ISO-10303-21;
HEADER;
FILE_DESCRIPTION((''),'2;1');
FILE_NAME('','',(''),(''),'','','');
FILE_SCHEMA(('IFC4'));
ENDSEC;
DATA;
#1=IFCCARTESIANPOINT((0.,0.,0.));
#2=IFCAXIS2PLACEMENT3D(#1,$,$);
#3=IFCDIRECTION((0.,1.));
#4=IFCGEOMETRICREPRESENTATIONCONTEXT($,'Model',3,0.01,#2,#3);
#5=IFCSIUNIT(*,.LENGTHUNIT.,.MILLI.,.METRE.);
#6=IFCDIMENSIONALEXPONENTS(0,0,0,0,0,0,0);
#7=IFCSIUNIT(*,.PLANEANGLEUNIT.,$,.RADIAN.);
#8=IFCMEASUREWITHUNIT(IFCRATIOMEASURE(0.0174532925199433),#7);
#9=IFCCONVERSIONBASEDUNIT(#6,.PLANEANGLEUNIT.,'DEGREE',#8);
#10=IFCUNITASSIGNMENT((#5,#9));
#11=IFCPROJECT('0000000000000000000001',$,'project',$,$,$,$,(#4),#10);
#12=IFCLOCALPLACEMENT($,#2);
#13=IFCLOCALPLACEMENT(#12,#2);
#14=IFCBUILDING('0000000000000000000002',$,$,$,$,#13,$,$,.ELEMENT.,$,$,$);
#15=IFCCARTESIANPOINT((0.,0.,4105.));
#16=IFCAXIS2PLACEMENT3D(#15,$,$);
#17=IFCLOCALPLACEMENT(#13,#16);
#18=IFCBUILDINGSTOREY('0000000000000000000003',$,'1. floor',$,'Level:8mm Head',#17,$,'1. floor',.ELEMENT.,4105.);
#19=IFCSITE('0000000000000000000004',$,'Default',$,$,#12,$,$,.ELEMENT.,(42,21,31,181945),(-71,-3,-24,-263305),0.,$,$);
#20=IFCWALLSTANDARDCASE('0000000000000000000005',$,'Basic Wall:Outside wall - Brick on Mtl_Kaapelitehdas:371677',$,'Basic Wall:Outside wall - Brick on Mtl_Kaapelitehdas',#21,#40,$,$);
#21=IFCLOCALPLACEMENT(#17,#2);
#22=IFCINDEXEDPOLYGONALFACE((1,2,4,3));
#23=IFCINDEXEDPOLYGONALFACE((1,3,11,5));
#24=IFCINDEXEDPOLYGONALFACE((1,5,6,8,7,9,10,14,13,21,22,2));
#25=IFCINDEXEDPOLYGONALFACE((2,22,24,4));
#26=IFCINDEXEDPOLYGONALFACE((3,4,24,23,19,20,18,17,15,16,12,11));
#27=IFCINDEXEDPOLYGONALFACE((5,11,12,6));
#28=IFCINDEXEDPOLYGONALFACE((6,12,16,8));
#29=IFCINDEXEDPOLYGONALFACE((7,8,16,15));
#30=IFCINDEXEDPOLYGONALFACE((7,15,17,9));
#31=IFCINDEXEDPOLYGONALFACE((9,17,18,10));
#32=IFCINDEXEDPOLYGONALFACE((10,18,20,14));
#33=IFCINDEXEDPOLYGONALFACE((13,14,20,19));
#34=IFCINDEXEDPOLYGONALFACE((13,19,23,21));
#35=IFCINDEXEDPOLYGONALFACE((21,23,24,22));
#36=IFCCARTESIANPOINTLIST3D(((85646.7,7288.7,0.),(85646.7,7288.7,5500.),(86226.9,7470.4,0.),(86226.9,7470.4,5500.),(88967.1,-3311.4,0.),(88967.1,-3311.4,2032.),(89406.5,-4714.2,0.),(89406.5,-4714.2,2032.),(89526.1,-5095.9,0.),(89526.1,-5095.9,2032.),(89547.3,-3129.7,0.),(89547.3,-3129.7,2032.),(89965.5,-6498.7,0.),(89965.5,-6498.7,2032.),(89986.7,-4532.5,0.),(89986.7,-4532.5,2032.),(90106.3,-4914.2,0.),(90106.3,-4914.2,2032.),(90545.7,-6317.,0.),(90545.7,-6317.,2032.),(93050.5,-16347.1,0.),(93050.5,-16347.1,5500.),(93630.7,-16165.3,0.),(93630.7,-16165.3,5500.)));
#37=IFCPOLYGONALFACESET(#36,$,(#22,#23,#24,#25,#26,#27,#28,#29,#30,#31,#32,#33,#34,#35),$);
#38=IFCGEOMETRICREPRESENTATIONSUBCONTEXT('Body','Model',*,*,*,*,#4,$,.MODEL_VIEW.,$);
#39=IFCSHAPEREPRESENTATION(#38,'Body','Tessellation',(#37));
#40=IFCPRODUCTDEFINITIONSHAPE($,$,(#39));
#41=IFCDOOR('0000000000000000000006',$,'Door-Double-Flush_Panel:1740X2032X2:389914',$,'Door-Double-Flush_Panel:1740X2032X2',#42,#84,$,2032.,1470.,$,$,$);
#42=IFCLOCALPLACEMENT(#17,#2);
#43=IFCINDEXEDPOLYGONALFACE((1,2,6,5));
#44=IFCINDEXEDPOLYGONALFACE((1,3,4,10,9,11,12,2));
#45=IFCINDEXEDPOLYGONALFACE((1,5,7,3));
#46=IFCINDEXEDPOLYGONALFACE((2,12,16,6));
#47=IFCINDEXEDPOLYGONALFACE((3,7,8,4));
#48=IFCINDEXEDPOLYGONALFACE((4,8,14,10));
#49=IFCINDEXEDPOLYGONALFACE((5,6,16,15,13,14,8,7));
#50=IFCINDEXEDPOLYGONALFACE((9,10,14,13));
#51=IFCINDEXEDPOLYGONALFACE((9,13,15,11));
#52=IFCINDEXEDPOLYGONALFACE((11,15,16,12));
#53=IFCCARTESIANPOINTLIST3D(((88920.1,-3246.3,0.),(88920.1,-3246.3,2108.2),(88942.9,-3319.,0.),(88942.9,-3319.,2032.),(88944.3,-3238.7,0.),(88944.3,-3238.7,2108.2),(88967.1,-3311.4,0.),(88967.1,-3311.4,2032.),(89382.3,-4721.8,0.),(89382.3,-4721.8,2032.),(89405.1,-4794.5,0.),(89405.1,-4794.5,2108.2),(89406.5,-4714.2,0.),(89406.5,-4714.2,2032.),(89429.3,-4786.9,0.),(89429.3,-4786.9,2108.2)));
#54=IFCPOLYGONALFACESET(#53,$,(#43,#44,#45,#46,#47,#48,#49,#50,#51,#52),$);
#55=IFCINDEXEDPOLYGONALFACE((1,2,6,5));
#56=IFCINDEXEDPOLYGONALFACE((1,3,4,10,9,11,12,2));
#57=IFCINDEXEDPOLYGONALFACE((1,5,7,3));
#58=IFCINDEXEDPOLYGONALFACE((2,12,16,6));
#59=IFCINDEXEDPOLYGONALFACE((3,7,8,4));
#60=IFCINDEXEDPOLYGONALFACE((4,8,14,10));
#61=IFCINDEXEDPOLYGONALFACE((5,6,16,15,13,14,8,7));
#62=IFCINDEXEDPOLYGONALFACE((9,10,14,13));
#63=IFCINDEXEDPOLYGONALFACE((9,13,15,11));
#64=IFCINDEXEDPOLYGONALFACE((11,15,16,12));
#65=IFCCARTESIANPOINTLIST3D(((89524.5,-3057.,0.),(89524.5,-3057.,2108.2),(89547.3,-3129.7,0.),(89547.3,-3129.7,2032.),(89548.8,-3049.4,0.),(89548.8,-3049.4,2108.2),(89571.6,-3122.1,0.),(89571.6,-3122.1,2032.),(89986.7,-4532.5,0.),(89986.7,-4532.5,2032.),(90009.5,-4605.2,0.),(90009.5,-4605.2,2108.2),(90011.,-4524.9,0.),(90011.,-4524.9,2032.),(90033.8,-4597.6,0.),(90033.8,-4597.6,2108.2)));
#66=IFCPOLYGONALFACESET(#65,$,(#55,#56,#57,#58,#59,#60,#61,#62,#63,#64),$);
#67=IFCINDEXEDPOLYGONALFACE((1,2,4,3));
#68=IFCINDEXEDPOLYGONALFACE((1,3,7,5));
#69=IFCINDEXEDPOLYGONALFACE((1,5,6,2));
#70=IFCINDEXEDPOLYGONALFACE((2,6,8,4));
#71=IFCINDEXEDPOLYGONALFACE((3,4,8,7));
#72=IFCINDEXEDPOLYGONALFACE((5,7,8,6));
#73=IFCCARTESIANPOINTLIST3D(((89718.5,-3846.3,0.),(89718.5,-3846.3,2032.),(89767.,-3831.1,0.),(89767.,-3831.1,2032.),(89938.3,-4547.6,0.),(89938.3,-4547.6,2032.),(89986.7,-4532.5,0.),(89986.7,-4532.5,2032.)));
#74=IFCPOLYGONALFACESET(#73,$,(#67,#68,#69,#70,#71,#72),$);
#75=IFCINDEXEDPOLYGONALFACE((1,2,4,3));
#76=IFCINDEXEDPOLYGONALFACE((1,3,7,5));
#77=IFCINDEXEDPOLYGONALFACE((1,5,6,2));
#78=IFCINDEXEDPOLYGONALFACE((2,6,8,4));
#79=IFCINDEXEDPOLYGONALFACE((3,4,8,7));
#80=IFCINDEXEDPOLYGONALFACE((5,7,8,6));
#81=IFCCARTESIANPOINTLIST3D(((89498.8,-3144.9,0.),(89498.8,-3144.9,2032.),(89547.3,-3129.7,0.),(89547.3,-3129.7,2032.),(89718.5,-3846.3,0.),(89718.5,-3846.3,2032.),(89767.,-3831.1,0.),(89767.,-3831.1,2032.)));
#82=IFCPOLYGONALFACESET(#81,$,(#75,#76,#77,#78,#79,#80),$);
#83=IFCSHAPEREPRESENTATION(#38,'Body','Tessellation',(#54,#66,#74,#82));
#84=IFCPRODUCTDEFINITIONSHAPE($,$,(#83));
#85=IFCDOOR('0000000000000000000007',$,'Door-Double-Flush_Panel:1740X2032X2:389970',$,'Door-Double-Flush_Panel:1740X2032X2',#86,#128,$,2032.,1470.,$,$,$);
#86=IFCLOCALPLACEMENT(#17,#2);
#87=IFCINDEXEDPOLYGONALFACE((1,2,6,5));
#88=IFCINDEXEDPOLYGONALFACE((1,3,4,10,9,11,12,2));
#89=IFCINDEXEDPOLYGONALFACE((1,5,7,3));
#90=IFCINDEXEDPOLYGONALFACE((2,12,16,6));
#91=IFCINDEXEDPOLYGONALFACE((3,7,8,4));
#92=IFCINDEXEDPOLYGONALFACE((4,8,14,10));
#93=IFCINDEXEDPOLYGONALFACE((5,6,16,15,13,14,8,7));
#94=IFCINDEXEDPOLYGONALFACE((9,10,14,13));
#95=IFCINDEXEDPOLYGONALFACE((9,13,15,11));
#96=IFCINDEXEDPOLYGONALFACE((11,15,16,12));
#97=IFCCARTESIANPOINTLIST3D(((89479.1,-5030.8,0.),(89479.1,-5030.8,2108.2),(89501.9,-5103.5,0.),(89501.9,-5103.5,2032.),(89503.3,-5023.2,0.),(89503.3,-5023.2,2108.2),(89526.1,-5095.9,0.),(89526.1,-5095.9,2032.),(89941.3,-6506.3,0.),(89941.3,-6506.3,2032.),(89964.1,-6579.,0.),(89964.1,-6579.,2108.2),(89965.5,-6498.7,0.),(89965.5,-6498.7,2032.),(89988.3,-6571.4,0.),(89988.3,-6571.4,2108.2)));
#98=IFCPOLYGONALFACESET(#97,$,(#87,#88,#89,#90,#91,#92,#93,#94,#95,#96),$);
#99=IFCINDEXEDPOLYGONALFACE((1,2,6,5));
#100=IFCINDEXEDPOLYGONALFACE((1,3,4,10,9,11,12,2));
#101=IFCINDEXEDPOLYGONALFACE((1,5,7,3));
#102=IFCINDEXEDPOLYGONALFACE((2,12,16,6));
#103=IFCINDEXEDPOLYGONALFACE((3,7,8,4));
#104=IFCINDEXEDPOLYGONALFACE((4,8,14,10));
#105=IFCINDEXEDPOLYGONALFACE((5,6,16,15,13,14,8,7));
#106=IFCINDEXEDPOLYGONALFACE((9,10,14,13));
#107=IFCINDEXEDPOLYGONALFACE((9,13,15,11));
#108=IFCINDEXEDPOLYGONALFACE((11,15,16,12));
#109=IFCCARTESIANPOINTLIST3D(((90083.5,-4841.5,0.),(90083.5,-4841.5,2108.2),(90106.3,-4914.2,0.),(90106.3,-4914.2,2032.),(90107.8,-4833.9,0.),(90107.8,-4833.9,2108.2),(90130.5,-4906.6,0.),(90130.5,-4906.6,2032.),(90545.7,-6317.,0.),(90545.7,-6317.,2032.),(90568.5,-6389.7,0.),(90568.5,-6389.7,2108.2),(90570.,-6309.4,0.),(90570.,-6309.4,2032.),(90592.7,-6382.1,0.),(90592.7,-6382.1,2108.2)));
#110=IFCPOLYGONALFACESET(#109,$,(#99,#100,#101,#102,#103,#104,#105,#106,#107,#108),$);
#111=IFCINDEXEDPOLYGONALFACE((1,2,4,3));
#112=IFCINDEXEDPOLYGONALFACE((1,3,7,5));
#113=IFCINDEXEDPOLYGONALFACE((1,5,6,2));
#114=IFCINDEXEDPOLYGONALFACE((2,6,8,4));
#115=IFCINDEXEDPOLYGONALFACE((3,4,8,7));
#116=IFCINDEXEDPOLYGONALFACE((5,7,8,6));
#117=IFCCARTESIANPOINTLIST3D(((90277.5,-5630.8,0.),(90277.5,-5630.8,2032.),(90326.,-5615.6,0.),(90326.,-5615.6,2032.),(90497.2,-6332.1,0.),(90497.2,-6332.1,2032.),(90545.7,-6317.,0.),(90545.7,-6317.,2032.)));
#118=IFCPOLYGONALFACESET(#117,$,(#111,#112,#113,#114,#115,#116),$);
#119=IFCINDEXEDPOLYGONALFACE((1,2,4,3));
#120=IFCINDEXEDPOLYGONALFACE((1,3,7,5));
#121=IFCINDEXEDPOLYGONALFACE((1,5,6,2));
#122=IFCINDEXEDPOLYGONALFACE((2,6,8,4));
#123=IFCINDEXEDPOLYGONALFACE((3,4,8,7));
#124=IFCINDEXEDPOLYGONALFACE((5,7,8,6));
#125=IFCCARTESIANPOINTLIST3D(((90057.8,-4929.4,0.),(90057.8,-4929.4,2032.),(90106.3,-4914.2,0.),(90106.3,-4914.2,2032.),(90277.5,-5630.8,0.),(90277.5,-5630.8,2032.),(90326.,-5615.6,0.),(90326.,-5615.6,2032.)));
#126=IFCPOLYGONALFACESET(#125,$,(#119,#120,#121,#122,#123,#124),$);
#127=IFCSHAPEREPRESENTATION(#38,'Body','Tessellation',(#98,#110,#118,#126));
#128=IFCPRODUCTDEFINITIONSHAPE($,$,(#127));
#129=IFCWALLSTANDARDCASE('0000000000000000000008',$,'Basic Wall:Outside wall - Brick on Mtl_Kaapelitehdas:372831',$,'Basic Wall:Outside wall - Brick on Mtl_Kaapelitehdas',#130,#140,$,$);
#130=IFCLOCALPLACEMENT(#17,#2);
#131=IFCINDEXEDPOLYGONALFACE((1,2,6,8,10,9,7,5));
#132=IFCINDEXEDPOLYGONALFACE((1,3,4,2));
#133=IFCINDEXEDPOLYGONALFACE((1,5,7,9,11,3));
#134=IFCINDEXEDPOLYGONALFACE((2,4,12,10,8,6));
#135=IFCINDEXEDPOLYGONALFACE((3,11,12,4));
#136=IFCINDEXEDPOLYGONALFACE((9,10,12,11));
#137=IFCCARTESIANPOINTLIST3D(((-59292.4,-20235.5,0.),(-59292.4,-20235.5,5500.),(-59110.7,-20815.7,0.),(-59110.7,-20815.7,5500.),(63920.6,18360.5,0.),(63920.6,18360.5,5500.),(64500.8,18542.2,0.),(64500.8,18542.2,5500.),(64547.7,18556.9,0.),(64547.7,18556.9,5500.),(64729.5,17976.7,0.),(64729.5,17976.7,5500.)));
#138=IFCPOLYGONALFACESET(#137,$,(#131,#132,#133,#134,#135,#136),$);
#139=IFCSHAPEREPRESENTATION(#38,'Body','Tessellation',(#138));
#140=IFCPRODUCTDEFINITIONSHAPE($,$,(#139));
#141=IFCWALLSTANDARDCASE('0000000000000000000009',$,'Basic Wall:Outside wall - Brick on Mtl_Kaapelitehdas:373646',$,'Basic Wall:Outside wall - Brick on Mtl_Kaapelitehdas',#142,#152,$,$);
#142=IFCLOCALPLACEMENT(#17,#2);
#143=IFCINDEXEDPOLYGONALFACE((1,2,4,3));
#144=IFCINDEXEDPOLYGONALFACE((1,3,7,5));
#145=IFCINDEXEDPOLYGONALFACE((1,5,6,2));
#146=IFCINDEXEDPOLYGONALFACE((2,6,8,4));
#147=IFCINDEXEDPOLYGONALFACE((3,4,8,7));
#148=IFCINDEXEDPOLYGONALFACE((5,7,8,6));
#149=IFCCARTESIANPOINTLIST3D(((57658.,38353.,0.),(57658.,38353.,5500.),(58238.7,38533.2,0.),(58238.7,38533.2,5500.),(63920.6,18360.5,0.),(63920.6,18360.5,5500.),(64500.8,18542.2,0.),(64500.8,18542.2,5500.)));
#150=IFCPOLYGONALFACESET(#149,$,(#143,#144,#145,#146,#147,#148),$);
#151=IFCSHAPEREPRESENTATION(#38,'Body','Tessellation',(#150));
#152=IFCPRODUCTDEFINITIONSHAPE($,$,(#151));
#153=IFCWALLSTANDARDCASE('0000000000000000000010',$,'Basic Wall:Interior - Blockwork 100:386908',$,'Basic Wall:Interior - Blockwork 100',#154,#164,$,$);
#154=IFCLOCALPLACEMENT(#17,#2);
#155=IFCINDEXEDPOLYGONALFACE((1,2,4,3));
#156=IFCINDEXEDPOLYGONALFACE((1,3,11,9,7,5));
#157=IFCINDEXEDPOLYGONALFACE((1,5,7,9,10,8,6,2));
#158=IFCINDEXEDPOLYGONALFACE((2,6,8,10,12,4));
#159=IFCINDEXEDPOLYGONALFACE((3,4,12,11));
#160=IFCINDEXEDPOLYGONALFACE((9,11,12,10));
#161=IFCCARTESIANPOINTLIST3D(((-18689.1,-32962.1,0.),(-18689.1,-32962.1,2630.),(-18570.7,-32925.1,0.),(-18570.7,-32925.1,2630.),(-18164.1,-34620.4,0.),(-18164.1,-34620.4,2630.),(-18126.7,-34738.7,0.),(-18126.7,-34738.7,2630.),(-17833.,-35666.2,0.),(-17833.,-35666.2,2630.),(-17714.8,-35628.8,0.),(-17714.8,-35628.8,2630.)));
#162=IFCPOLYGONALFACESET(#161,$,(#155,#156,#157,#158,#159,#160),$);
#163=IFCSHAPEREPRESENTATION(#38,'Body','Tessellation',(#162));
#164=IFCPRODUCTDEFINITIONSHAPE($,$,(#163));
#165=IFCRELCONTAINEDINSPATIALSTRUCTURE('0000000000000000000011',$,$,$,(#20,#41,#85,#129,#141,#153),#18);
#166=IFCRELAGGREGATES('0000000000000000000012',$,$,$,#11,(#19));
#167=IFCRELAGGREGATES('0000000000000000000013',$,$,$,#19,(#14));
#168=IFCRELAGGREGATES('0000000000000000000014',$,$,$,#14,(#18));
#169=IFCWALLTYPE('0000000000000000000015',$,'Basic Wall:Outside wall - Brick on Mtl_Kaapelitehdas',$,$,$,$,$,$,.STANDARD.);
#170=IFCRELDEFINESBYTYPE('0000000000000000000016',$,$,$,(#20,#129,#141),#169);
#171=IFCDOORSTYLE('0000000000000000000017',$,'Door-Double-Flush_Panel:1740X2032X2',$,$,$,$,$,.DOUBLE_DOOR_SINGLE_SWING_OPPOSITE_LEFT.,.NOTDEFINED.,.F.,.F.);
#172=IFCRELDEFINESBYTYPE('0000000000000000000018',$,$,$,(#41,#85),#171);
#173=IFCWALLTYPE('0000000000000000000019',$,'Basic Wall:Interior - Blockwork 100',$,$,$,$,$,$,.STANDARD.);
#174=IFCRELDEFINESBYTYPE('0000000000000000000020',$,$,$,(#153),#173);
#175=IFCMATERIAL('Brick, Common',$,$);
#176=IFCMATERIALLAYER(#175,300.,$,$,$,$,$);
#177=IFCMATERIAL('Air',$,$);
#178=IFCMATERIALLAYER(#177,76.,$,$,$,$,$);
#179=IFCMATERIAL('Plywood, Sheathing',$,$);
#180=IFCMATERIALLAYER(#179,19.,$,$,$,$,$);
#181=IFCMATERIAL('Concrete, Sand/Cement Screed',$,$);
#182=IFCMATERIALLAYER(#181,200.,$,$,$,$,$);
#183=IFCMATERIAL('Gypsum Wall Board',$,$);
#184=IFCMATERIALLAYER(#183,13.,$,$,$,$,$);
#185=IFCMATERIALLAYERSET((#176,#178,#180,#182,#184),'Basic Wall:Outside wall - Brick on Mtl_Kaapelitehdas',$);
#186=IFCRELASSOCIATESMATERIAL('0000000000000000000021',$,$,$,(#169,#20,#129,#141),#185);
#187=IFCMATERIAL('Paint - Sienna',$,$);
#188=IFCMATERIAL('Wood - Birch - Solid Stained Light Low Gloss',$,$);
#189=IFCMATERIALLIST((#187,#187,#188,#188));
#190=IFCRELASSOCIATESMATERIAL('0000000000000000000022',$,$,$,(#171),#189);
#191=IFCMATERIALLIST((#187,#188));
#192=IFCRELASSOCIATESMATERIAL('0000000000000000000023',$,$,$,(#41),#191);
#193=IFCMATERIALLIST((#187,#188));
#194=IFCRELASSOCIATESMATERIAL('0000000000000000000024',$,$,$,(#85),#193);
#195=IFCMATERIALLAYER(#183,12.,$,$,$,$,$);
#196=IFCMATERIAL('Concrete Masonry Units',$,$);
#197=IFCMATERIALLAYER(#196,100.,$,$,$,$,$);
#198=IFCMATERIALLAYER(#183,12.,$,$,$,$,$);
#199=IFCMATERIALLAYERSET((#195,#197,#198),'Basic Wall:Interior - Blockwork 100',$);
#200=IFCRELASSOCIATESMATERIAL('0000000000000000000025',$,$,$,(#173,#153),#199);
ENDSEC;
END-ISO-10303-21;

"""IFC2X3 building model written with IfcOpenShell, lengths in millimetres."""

from ifc_helpers import new_model, entity, si_unit, converted_unit, direction, frame, frame_2d, origin, origin_2d_with_axis, place, context, subcontext, project, spatial, polyline, rectangle, outline, extrude, source, transform, mapped, material, material_list, layer, layer_set, layer_usage, type_object, type_shapes, element, fill, save


model = new_model("IFC2X3")

# Units and contexts
model_context = context("Model", 3, precision=0.01, world=origin(), true_north=direction((0.0, 1.0)))
body_context = subcontext(model_context, "Body", "Model", "MODEL_VIEW")
ifc_project = project(units=[si_unit("LENGTHUNIT", "METRE", prefix="MILLI"), converted_unit("PLANEANGLEUNIT", "DEGREE", entity("IfcRatioMeasure", 0.0174532925199433), si_unit("PLANEANGLEUNIT", "RADIAN"), dimensions=[0, 0, 0, 0, 0, 0, 0])], contexts=[model_context])

# Site, building, storey
site_placement = place(None, origin())
site = spatial("IfcSite", under=ifc_project, at=site_placement, Name="Default", CompositionType="ELEMENT", RefLatitude=(42, 21, 31, 181945), RefLongitude=(-71, -3, -24, -263305), RefElevation=0.0)
building_placement = place(site_placement, origin())
building = spatial("IfcBuilding", under=site, at=building_placement, CompositionType="ELEMENT")
storey_placement = place(building_placement, frame((0.0, 0.0, 4105.0)))
storey = spatial("IfcBuildingStorey", under=building, at=storey_placement, Name="1. floor", ObjectType="Level:8mm Head", LongName="1. floor", CompositionType="ELEMENT", Elevation=4105.0)

# Wall, openings, doors
ifc_material_1 = material(Name="Brick, Common")
ifc_layer_1 = layer(ifc_material_1, 300.0)
ifc_material_2 = material(Name="Air")
ifc_layer_2 = layer(ifc_material_2, 76.0)
ifc_material_3 = material(Name="Plywood, Sheathing")
ifc_layer_3 = layer(ifc_material_3, 19.0)
ifc_material_4 = material(Name="Concrete, Sand/Cement Screed")
ifc_layer_4 = layer(ifc_material_4, 200.0)
ifc_material_5 = material(Name="Gypsum Wall Board")
ifc_layer_5 = layer(ifc_material_5, 13.0)
ifc_layer_set_1 = layer_set([ifc_layer_1, ifc_layer_2, ifc_layer_3, ifc_layer_4, ifc_layer_5], Name="Basic Wall:Outside wall - Brick on Mtl_Kaapelitehdas")
wall_type_1 = type_object("IfcWallType", Name="Basic Wall:Outside wall - Brick on Mtl_Kaapelitehdas", PredefinedType="STANDARD", material=ifc_layer_set_1)
ifc_material_6 = material(Name="Paint - Sienna")
ifc_material_7 = material(Name="Wood - Birch - Solid Stained Light Low Gloss")
ifc_material_list_1 = material_list([ifc_material_6, ifc_material_6, ifc_material_7, ifc_material_7])
door_style_1 = type_object("IfcDoorStyle", Name="Door-Double-Flush_Panel:1740X2032X2", ConstructionType="NOTDEFINED", OperationType="DOUBLE_DOOR_SINGLE_SWING_OPPOSITE_LEFT", ParameterTakesPrecedence=False, Sizeable=False, material=ifc_material_list_1)
shared_shape_1 = source(origin(), body_context, "Body", "SweptSolid", [
    extrude(outline(polyline([(-997.0, 735.0), (1035.0, 735.0), (1035.0, 811.2), (-1073.2, 811.2), (-1073.2, -811.2), (1035.0, -811.2), (1035.0, -735.0), (-997.0, -735.0), (-997.0, 735.0)])), frame((735.0, -25.4, 1035.0), z_axis=(0.0, 1.0, 0.0), x_axis=(0.0, 0.0, -1.0)), (0.0, 0.0, 1.0), 25.4),
    extrude(outline(polyline([(-997.0, 735.0), (1035.0, 735.0), (1035.0, 811.2), (-1073.2, 811.2), (-1073.2, -811.2), (1035.0, -811.2), (1035.0, -735.0), (-997.0, -735.0), (-997.0, 735.0)])), frame((735.0, 608.0, 1035.0), z_axis=(0.0, 1.0, 0.0), x_axis=(0.0, 0.0, -1.0)), (0.0, 0.0, 1.0), 25.4),
    extrude(rectangle(XDim=50.8, YDim=735.0, at=origin_2d_with_axis()), frame((1102.5, 582.6, 0.0), z_axis=(0.0, 0.0, 1.0), x_axis=(0.0, -1.0, 0.0)), (0.0, 0.0, 1.0), 2032.0),
    extrude(rectangle(XDim=50.8, YDim=735.0, at=frame_2d((0.0, 0.0), x_axis=(1.0, 0.0))), frame((367.5, 582.6, 0.0), z_axis=(0.0, 0.0, 1.0), x_axis=(0.0, -1.0, 0.0)), (0.0, 0.0, 1.0), 2032.0),
])
type_shapes(door_style_1, [shared_shape_1])
ifc_layer_usage_1 = layer_usage(ifc_layer_set_1, "AXIS2", "NEGATIVE", 304.0)
wall_1_placement = place(storey_placement, frame((85936.8, 7379.6, 0.0), z_axis=(0.0, 0.0, 1.0), x_axis=(0.298924, -0.954277, 0.0)))
wall_1 = element("IfcWallStandardCase", 1, at=wall_1_placement, inside=storey, type_object=wall_type_1, material=ifc_layer_usage_1, Name="Basic Wall:Outside wall - Brick on Mtl_Kaapelitehdas:371677", ObjectType="Basic Wall:Outside wall - Brick on Mtl_Kaapelitehdas", context=body_context, shape_type="SweptSolid", body=[
    extrude(rectangle(XDim=24768.2, YDim=608.0, at=frame_2d((12384.1, 0.0), x_axis=(-1.0, 0.0))), origin(), (0.0, 0.0, 1.0), 5500.0),
])
opening_1_placement = place(wall_1_placement, frame((11108.0, -304.0, 0.0)))
opening_1 = element("IfcOpeningElement", 2, at=opening_1_placement, cuts=wall_1, ObjectType="Opening", context=body_context, shape_type="SweptSolid", body=[
    extrude(rectangle(XDim=2032.0, YDim=1470.0, at=frame_2d((1016.0, 735.0), x_axis=(1.0, 0.0))), frame((0.0, 0.0, 0.0), z_axis=(0.0, 1.0, 0.0), x_axis=(0.0, 0.0, 1.0)), (0.0, 0.0, 1.0), 608.0),
])
opening_2_placement = place(wall_1_placement, frame((12978.0, -304.0, 0.0)))
opening_2 = element("IfcOpeningElement", 3, at=opening_2_placement, cuts=wall_1, ObjectType="Opening", context=body_context, shape_type="SweptSolid", body=[
    extrude(rectangle(XDim=2032.0, YDim=1470.0, at=frame_2d((1016.0, 735.0), x_axis=(1.0, 0.0))), frame((0.0, 0.0, 0.0), z_axis=(0.0, 1.0, 0.0), x_axis=(0.0, 0.0, 1.0)), (0.0, 0.0, 1.0), 608.0),
])
ifc_material_list_2 = material_list([ifc_material_6, ifc_material_7])
door_1_placement = place(opening_1_placement, origin())
door_1 = element("IfcDoor", 4, at=door_1_placement, inside=storey, type_object=door_style_1, material=ifc_material_list_2, Name="Door-Double-Flush_Panel:1740X2032X2:389914", ObjectType="Door-Double-Flush_Panel:1740X2032X2", OverallHeight=2032.0, OverallWidth=1470.0, context=body_context, shape_type="MappedRepresentation", body=[
    mapped(shared_shape_1, transform((0.0, 0.0, 0.0), scale=1.0)),
])
fill(opening_1, door_1)
ifc_material_list_3 = material_list([ifc_material_6, ifc_material_7])
door_2_placement = place(opening_2_placement, origin())
door_2 = element("IfcDoor", 5, at=door_2_placement, inside=storey, type_object=door_style_1, material=ifc_material_list_3, Name="Door-Double-Flush_Panel:1740X2032X2:389970", ObjectType="Door-Double-Flush_Panel:1740X2032X2", OverallHeight=2032.0, OverallWidth=1470.0, context=body_context, shape_type="MappedRepresentation", body=[
    mapped(shared_shape_1, transform((0.0, 0.0, 0.0), scale=1.0)),
])
fill(opening_2, door_2)

# Walls
ifc_layer_usage_2 = layer_usage(ifc_layer_set_1, "AXIS2", "NEGATIVE", 304.0)
wall_2_placement = place(storey_placement, frame((64638.6, 18266.8, 0.0), z_axis=(0.0, 0.0, 1.0), x_axis=(-0.954277, -0.298924, 0.0)))
element("IfcWallStandardCase", 6, at=wall_2_placement, inside=storey, type_object=wall_type_1, material=ifc_layer_usage_2, Name="Basic Wall:Outside wall - Brick on Mtl_Kaapelitehdas:372831", ObjectType="Basic Wall:Outside wall - Brick on Mtl_Kaapelitehdas", context=body_context, shape_type="SweptSolid", body=[
    extrude(outline(polyline([(129773.8, -304.0), (129773.9, 304.0), (0.0, 304.0), (0.0, -304.0), (49.2, -304.0), (657.2, -304.0), (129773.8, -304.0)])), origin(), (0.0, 0.0, 1.0), 5500.0),
])
ifc_layer_usage_3 = layer_usage(ifc_layer_set_1, "AXIS2", "NEGATIVE", 304.0)
wall_3_placement = place(storey_placement, frame((57948.1, 38443.9, 0.0), z_axis=(0.0, 0.0, 1.0), x_axis=(0.298924, -0.954277, 0.0)))
element("IfcWallStandardCase", 7, at=wall_3_placement, inside=storey, type_object=wall_type_1, material=ifc_layer_usage_3, Name="Basic Wall:Outside wall - Brick on Mtl_Kaapelitehdas:373646", ObjectType="Basic Wall:Outside wall - Brick on Mtl_Kaapelitehdas", context=body_context, shape_type="SweptSolid", body=[
    extrude(outline(polyline([(20950.4, -304.0), (20950.4, 304.0), (1.6, 304.0), (0.0, -304.0), (20950.4, -304.0)])), origin(), (0.0, 0.0, 1.0), 5500.0),
])
ifc_layer_6 = layer(ifc_material_5, 12.0)
ifc_material_8 = material(Name="Concrete Masonry Units")
ifc_layer_7 = layer(ifc_material_8, 100.0)
ifc_layer_8 = layer(ifc_material_5, 12.0)
ifc_layer_set_2 = layer_set([ifc_layer_6, ifc_layer_7, ifc_layer_8], Name="Basic Wall:Interior - Blockwork 100")
ifc_layer_usage_4 = layer_usage(ifc_layer_set_2, "AXIS2", "NEGATIVE", 62.0)
wall_type_2 = type_object("IfcWallType", Name="Basic Wall:Interior - Blockwork 100", PredefinedType="STANDARD", material=ifc_layer_set_2)
wall_4_placement = place(storey_placement, frame((-17773.9, -35647.5, 0.0), z_axis=(0.0, 0.0, 1.0), x_axis=(-0.301797, 0.953372, 0.0)))
element("IfcWallStandardCase", 8, at=wall_4_placement, inside=storey, type_object=wall_type_2, material=ifc_layer_usage_4, Name="Basic Wall:Interior - Blockwork 100:386908", ObjectType="Basic Wall:Interior - Blockwork 100", context=body_context, shape_type="SweptSolid", body=[
    extrude(outline(polyline([(2836.0, -62.0), (2836.4, 62.0), (1096.9, 62.0), (972.9, 62.0), (0.0, 62.0), (0.0, -62.0), (2836.0, -62.0)])), origin(), (0.0, 0.0, 1.0), 2630.0),
])

save(model, "model.ifc")
